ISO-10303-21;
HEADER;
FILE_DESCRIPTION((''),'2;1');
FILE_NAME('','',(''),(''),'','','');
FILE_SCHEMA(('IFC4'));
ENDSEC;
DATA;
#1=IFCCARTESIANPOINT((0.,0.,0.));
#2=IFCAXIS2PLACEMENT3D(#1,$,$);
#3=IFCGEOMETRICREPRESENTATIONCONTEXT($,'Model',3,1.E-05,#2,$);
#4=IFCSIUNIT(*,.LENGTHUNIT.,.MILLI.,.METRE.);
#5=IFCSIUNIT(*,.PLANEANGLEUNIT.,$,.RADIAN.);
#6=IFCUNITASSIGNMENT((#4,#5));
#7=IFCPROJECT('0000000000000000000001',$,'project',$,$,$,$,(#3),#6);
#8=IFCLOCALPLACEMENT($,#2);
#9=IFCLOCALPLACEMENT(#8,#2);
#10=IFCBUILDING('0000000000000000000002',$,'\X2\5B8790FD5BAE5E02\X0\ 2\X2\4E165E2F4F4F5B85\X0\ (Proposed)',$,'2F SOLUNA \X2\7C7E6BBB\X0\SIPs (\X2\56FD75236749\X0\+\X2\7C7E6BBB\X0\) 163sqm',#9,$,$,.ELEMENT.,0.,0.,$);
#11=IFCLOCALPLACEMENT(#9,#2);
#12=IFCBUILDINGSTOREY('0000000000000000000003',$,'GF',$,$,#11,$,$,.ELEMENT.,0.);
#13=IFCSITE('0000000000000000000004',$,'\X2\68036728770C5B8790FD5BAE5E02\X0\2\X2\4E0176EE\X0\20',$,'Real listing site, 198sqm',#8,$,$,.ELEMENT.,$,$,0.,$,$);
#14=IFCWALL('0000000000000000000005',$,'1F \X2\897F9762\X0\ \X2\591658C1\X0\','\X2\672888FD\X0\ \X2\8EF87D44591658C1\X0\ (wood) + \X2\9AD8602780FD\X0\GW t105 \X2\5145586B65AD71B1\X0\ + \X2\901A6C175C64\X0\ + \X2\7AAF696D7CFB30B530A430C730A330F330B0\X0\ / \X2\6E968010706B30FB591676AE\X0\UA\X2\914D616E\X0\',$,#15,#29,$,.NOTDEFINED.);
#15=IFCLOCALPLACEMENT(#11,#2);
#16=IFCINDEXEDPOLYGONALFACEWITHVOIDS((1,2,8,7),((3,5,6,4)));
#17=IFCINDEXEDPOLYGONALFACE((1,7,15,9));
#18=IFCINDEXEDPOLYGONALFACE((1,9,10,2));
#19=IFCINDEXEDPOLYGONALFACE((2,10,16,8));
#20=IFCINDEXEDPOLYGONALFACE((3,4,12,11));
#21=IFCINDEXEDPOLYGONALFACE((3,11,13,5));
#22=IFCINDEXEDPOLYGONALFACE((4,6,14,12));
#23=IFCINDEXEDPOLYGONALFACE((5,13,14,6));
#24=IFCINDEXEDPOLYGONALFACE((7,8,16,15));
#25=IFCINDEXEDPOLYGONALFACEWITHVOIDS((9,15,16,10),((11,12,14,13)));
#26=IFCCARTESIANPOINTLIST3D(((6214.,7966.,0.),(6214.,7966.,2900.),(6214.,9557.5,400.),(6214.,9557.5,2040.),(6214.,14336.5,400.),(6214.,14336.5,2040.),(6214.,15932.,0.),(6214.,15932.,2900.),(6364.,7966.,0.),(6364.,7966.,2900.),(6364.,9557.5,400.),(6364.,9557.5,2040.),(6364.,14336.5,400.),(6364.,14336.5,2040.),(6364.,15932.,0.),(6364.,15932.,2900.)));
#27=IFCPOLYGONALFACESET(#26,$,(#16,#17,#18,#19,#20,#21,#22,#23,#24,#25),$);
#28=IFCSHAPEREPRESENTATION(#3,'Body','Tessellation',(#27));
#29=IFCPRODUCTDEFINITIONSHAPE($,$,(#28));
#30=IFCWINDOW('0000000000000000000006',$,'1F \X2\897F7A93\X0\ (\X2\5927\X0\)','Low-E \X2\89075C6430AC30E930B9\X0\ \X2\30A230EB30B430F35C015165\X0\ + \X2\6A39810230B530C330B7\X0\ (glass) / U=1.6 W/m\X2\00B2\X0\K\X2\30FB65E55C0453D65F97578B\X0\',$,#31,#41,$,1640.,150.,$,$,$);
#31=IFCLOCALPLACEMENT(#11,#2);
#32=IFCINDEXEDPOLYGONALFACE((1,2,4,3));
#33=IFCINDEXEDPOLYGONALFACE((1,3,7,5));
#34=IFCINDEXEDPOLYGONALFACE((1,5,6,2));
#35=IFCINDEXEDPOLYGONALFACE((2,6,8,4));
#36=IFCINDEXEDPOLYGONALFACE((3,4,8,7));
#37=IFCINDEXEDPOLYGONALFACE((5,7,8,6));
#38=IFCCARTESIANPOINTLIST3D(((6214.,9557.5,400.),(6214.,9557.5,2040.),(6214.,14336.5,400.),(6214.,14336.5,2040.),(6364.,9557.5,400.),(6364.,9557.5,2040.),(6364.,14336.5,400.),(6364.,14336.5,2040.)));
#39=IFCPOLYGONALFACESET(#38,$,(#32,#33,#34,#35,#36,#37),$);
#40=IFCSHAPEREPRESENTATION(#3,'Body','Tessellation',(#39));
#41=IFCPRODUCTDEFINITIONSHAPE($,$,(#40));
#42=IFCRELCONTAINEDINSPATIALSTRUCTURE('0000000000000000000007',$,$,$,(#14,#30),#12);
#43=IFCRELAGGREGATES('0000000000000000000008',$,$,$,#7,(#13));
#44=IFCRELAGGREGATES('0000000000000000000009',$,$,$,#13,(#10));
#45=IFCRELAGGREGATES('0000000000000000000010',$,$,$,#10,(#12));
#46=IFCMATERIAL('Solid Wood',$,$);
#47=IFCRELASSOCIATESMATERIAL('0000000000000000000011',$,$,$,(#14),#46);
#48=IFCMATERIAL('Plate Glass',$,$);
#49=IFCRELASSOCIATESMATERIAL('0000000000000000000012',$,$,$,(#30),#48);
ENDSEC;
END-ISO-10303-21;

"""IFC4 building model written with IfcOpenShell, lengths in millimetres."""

from ifc_helpers import new_model, si_unit, frame, frame_2d, origin, place, context, project, spatial, rectangle, extrude, material, element, fill, save


model = new_model("IFC4")

# Units and contexts
model_context = context("Model", 3, precision=1e-05, world=origin())
ifc_project = project(units=[si_unit("LENGTHUNIT", "METRE", prefix="MILLI"), si_unit("PLANEANGLEUNIT", "RADIAN")], contexts=[model_context])

# Site, building, storey
site_placement = place(None, origin())
site = spatial("IfcSite", under=ifc_project, at=site_placement, Name="栃木県宇都宮市2丁目20", ObjectType="Real listing site, 198sqm", CompositionType="ELEMENT", RefElevation=0.0)
building_placement = place(site_placement, origin())
building = spatial("IfcBuilding", under=site, at=building_placement, Name="宇都宮市 2世帯住宅 (Proposed)", ObjectType="2F SOLUNA 籾殻SIPs (国産杉+籾殻) 163sqm", CompositionType="ELEMENT", ElevationOfRefHeight=0.0, ElevationOfTerrain=0.0)
storey_placement = place(building_placement, origin())
storey = spatial("IfcBuildingStorey", under=building, at=storey_placement, Name="GF", CompositionType="ELEMENT", Elevation=0.0)

# Shared definitions
ifc_material_1 = material(Name="Solid Wood")

# Shared definitions
ifc_material_2 = material(Name="Plate Glass")

# Wall, opening, window
wall_1_placement = place(storey_placement, frame((3107.0, 3983.0, 0.0)))
wall_1 = element("IfcWall", 1, at=wall_1_placement, inside=storey, material=ifc_material_1, Name="1F 西面 外壁", Description="木製 軸組外壁 (wood) + 高性能GW t105 充填断熱 + 通気層 + 窯業系サイディング / 準耐火・外皮UA配慮", PredefinedType="NOTDEFINED", context=model_context, shape_type="SweptSolid", body=[
    extrude(rectangle(XDim=150.0, YDim=7966.0, at=frame_2d((75.0, 3983.0))), frame((3107.0, 3983.0, 0.0)), (0.0, 0.0, 1.0), 2900.0),
])
opening_1_placement = place(storey_placement, frame((3107.0, 4779.0, 200.0)))
opening_1 = element("IfcOpeningElement", 2, at=opening_1_placement, cuts=wall_1, PredefinedType="NOTDEFINED", context=model_context, shape_type="SweptSolid", body=[
    extrude(rectangle(XDim=150.0, YDim=4779.0, at=frame_2d((75.0, 2389.0))), frame((3107.0, 4779.0, 200.0)), (0.0, 0.0, 1.0), 1640.0),
])
window_1_placement = place(storey_placement, frame((3107.0, 4779.0, 200.0)))
window_1 = element("IfcWindow", 3, at=window_1_placement, inside=storey, material=ifc_material_2, Name="1F 西窓 (大)", Description="Low-E 複層ガラス アルゴン封入 + 樹脂サッシ (glass) / U=1.6 W/m²K・日射取得型", OverallHeight=1640.0, OverallWidth=150.0, context=model_context, shape_type="SweptSolid", body=[
    extrude(rectangle(XDim=150.0, YDim=4779.0, at=frame_2d((75.0, 2389.0))), frame((3107.0, 4779.0, 200.0)), (0.0, 0.0, 1.0), 1640.0),
])
fill(opening_1, window_1)

save(model, "model.ifc")
